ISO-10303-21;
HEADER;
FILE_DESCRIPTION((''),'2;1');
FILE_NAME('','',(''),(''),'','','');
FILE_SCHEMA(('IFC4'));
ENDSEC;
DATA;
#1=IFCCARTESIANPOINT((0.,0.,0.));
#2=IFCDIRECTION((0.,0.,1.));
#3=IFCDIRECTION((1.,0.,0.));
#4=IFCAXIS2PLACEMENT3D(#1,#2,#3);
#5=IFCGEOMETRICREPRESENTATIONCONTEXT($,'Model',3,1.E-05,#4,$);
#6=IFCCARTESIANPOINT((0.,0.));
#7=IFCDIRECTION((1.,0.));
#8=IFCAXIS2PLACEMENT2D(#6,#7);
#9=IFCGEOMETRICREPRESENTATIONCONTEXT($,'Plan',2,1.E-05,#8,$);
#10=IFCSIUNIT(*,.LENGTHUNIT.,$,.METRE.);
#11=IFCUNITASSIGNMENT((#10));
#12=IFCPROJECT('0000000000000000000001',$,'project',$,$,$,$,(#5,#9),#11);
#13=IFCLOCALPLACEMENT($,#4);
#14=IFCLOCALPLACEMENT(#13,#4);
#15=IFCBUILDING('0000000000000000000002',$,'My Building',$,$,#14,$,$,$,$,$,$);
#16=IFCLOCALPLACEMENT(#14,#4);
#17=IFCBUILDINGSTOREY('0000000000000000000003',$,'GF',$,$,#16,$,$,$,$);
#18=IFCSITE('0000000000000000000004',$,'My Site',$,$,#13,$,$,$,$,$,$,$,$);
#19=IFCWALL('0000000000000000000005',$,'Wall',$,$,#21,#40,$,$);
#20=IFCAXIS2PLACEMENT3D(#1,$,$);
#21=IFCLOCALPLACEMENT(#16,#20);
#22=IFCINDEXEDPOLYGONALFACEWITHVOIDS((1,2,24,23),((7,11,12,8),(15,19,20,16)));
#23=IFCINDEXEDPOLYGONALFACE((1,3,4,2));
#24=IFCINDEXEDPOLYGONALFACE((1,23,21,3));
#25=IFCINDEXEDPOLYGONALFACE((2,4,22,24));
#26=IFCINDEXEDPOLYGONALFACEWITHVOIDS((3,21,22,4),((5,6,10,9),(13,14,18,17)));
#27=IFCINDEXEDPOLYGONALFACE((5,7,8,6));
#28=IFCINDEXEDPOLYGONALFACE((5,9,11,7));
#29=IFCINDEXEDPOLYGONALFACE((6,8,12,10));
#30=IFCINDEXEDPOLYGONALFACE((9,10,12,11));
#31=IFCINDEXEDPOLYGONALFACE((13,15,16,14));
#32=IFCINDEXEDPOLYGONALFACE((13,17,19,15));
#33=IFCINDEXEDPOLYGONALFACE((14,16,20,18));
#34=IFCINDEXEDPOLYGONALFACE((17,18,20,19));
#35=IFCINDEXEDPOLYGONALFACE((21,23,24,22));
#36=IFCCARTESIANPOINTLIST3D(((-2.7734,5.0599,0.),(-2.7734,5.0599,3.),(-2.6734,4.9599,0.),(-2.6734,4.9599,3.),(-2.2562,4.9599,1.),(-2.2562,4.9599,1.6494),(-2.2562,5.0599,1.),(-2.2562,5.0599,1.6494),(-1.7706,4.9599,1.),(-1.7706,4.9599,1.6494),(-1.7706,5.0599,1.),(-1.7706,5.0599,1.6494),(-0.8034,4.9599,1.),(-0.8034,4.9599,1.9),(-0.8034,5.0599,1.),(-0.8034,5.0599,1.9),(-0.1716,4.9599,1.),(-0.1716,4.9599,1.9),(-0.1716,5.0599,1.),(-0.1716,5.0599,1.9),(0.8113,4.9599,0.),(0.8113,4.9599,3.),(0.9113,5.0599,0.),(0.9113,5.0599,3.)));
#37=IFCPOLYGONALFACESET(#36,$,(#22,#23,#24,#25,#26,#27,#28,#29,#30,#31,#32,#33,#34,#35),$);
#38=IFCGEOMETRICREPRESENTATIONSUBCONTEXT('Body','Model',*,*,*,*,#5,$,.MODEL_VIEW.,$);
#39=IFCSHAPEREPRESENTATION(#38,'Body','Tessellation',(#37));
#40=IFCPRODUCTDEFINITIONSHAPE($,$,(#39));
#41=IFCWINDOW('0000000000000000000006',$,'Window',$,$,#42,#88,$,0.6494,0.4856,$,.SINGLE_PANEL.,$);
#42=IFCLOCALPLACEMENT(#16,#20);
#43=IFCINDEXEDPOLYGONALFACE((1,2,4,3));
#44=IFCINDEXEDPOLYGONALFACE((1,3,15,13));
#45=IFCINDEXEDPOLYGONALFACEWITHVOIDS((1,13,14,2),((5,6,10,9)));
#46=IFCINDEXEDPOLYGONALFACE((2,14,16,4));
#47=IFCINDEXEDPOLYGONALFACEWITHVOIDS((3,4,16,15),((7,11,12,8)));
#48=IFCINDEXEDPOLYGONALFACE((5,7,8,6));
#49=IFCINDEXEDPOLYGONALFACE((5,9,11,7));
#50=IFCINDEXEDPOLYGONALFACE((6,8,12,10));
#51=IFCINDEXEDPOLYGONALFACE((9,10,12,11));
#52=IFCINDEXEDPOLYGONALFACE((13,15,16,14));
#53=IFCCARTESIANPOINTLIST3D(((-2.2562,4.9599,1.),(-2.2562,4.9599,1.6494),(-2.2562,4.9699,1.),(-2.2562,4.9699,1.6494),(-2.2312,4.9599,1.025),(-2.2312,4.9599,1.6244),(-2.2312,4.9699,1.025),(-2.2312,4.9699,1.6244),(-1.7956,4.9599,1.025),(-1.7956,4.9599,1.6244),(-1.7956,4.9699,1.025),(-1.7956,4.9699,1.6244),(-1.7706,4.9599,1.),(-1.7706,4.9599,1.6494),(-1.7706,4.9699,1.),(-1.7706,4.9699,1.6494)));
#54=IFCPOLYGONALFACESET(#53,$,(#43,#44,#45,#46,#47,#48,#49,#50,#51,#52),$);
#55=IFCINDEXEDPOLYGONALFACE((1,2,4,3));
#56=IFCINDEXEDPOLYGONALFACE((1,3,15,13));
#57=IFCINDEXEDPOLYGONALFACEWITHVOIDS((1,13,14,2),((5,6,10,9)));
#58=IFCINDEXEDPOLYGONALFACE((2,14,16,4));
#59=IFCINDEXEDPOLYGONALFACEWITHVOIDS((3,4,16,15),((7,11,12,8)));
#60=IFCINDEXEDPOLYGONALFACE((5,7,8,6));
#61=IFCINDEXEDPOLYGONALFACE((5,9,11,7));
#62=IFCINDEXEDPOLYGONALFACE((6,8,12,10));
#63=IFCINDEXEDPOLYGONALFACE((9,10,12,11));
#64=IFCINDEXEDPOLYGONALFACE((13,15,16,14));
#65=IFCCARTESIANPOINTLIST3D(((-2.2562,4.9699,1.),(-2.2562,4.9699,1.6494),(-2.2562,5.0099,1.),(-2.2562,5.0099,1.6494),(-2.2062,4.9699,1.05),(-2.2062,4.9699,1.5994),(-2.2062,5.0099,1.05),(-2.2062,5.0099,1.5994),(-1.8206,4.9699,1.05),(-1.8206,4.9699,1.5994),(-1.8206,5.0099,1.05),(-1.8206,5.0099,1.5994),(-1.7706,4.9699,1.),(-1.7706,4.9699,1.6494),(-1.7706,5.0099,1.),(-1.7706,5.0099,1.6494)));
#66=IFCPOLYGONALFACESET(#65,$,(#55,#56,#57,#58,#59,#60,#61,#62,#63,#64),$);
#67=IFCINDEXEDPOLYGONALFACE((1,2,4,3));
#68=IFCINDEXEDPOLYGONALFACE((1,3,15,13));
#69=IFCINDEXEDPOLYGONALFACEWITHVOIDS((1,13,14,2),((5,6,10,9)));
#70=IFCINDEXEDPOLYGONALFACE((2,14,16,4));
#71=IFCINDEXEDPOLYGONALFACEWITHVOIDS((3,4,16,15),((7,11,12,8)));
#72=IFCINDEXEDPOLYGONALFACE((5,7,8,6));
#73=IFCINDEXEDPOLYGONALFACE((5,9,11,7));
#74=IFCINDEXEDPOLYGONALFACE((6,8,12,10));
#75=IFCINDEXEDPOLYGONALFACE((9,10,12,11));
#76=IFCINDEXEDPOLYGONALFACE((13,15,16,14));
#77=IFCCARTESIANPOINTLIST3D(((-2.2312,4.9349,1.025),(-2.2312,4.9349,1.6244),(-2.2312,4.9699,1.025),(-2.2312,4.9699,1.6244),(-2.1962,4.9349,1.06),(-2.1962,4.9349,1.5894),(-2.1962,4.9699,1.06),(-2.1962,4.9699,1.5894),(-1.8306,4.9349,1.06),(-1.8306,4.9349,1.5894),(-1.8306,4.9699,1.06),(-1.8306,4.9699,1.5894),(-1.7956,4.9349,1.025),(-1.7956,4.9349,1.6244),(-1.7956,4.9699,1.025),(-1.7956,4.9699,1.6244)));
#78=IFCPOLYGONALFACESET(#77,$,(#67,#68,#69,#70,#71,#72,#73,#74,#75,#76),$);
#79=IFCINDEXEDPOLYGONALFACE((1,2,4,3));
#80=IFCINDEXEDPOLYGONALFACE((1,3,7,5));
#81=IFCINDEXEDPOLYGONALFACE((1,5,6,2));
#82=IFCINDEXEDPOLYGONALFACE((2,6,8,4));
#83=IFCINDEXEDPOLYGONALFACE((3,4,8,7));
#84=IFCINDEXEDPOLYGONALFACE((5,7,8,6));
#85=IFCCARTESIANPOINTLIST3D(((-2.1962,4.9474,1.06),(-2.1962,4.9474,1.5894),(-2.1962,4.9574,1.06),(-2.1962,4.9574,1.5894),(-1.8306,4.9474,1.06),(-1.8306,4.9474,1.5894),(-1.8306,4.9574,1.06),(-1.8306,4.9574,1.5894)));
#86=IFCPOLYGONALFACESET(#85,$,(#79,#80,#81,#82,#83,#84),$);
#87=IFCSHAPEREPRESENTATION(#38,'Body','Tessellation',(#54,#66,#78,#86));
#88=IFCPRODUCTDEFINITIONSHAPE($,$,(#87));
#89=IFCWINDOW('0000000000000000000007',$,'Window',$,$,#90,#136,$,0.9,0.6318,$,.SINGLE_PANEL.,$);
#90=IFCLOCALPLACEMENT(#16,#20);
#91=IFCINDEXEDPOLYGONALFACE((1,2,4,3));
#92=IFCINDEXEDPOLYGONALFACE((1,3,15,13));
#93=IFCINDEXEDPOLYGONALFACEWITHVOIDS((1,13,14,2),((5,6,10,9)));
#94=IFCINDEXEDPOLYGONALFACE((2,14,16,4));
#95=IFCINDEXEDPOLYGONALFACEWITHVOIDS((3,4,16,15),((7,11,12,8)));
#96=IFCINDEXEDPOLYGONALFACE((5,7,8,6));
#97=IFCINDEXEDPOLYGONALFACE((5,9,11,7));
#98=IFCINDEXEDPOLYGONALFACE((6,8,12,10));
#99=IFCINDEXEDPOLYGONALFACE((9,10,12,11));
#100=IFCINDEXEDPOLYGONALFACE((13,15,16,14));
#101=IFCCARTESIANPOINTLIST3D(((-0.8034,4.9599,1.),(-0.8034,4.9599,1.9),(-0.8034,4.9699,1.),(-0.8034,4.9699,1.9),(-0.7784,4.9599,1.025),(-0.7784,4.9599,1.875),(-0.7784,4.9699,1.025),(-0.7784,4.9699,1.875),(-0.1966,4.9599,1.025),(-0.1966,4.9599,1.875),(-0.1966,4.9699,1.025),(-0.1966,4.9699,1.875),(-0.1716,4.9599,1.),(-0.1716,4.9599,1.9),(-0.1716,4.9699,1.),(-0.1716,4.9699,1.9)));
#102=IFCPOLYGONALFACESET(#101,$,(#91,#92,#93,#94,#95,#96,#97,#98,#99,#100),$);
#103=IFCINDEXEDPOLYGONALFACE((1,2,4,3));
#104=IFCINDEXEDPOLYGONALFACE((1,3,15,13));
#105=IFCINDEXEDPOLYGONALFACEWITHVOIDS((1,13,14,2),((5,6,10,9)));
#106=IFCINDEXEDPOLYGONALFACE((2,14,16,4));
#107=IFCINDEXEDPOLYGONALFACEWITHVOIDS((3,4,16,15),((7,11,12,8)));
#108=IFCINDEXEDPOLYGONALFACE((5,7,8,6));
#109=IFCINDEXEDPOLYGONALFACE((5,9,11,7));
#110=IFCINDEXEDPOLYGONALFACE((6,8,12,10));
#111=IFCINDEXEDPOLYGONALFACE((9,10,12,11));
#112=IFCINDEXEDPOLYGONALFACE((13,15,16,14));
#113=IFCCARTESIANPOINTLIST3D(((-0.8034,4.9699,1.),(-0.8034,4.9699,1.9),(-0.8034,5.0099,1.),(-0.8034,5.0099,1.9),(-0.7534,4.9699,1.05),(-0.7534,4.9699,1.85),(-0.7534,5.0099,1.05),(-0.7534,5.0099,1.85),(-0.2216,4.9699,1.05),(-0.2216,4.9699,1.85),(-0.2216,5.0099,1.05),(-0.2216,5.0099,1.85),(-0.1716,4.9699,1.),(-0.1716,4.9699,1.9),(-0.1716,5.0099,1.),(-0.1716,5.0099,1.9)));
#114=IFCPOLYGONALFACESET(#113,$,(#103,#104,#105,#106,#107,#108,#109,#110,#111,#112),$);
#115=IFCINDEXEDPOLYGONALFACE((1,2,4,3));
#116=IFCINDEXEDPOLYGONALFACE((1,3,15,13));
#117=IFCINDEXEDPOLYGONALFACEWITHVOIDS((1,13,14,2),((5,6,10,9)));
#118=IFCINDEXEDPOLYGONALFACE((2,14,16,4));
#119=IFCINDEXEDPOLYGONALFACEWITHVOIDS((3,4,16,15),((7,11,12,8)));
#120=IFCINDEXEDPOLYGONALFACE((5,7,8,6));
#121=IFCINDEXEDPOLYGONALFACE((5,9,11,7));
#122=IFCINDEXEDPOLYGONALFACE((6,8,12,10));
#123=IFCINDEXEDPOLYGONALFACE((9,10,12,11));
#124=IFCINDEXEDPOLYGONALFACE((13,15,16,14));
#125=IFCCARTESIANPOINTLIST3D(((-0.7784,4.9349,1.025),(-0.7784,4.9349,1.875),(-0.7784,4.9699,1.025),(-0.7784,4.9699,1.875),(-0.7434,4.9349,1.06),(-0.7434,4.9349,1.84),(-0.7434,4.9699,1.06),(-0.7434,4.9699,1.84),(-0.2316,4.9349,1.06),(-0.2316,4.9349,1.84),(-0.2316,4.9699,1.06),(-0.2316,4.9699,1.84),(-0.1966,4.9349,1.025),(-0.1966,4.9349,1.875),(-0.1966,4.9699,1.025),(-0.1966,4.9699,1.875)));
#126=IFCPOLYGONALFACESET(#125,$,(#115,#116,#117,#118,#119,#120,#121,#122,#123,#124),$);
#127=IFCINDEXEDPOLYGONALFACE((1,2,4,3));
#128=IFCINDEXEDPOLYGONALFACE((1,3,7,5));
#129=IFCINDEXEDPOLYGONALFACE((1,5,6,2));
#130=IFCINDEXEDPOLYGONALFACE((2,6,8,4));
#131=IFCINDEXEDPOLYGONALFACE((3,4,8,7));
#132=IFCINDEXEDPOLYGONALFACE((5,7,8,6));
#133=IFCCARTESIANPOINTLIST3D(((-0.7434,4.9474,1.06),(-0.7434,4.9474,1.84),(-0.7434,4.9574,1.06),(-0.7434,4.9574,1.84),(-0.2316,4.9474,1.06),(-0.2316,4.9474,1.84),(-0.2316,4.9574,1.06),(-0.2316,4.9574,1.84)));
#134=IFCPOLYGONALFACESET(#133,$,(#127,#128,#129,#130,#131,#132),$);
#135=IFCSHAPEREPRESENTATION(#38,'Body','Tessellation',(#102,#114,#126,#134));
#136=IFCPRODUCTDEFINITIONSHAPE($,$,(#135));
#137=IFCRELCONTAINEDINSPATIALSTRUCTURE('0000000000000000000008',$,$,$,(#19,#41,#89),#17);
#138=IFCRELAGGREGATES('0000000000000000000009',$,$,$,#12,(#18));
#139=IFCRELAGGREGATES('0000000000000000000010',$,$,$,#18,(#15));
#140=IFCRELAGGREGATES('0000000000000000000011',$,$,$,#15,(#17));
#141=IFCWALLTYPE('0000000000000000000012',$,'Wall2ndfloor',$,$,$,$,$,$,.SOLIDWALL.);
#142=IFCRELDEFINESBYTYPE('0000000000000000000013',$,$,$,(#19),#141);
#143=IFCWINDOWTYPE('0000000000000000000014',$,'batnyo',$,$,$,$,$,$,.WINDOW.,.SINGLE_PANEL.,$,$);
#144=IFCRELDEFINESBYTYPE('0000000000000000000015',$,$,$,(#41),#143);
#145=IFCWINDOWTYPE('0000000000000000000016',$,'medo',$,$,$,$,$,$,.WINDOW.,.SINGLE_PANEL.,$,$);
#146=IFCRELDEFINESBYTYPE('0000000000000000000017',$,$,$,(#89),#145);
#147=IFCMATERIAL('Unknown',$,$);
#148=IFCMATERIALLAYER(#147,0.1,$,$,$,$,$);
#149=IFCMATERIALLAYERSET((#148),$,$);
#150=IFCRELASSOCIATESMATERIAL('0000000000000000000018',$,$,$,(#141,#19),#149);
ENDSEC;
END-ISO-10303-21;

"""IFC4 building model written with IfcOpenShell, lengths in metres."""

from ifc_helpers import new_model, entity, si_unit, frame, origin_with_axes, origin_2d_with_axis, place, context, subcontext, project, spatial, line, indexed_curve, outline, extrude, shape, source, transform, mapped, material, layer, layer_set, layer_usage, type_object, type_shapes, element, fill, save


model = new_model("IFC4")

# Units and contexts
model_context = context("Model", 3, precision=1e-05, world=origin_with_axes())
plan_context = context("Plan", 2, precision=1e-05, world=origin_2d_with_axis())
body_context_1 = subcontext(model_context, "Body", "Model", "MODEL_VIEW")
body_context_2 = subcontext(plan_context, "Body", "Plan", "PLAN_VIEW")
ifc_project = project(units=[si_unit("LENGTHUNIT", "METRE")], contexts=[model_context, plan_context])

# Site, building, storey
site_placement = place(None, origin_with_axes())
site = spatial("IfcSite", under=ifc_project, at=site_placement, Name="My Site")
building_placement = place(site_placement, origin_with_axes())
building = spatial("IfcBuilding", under=site, at=building_placement, Name="My Building")
storey_placement = place(building_placement, origin_with_axes())
storey = spatial("IfcBuildingStorey", under=building, at=storey_placement, Name="GF")

# Shared definitions
ifc_material = material(Name="Unknown")

# Shared definitions
ifc_layer_1 = layer(ifc_material, 0.1)
ifc_layer_set_1 = layer_set([ifc_layer_1])
wall_type = type_object("IfcWallType", Name="Wall2ndfloor", PredefinedType="SOLIDWALL", material=ifc_layer_set_1)

# Wall, openings, windows
ifc_layer_usage_1 = layer_usage(ifc_layer_set_1, "AXIS2", "POSITIVE", 0.0)
wall_1_placement = place(storey_placement, frame((0.9113, 5.0599, 0.0), z_axis=(0.0, 0.0, 1.0), x_axis=(-1.0, 0.0, 0.0)))
wall_1 = element("IfcWall", 1, at=wall_1_placement, inside=storey, type_object=wall_type, material=ifc_layer_usage_1, Name="Wall", context=body_context_1, shape_type="SweptSolid", body=[
    extrude(outline(indexed_curve([(0.0, 0.0), (0.1, 0.1), (3.5847, 0.1), (3.6847, 0.0)], segments=[line(1, 2, 3, 4, 1)])), origin_with_axes(), (0.0, 0.0, 1.0), 3.0),
])
shared_shape_1 = source(origin_with_axes(), body_context_1, "Body", "SweptSolid", [
    extrude(outline(indexed_curve([(0.0, 0.0), (0.4856, 0.0), (0.4856, 0.6494), (0.0, 0.6494)], segments=[line(1, 2, 3, 4, 1)])), frame((0.0, -0.6, 0.0), z_axis=(0.0, -1.0, 0.0), x_axis=(1.0, 0.0, 0.0)), (0.0, 0.0, -1.0), 1.2),
])
opening_1_placement = place(wall_1_placement, frame((2.6819, 0.0, 1.0), z_axis=(0.0, 0.0, 1.0), x_axis=(1.0, 0.0, 0.0)))
opening_1 = element("IfcOpeningElement", 2, at=opening_1_placement, cuts=wall_1, PredefinedType="OPENING", context=body_context_1, shape_type="MappedRepresentation", body=[
    mapped(shared_shape_1, transform((0.0, 0.0, 0.0), x_axis=(1.0, 0.0, 0.0), y_axis=(0.0, 1.0, 0.0), z_axis=(0.0, 0.0, 1.0), scale=1.0)),
])
shared_shape_2 = source(origin_with_axes(), body_context_1, "Body", "SweptSolid", [
    extrude(outline(indexed_curve([(0.0, 0.0), (0.6318, 0.0), (0.6318, 0.9), (0.0, 0.9)], segments=[line(1, 2, 3, 4, 1)])), frame((0.0, -0.6, 0.0), z_axis=(0.0, -1.0, 0.0), x_axis=(1.0, 0.0, 0.0)), (0.0, 0.0, -1.0), 1.2),
])
opening_2_placement = place(wall_1_placement, frame((1.083, 0.0, 1.0), z_axis=(0.0, 0.0, 1.0), x_axis=(1.0, 0.0, 0.0)))
opening_2 = element("IfcOpeningElement", 3, at=opening_2_placement, cuts=wall_1, PredefinedType="OPENING", context=body_context_1, shape_type="MappedRepresentation", body=[
    mapped(shared_shape_2, transform((0.0, 0.0, 0.0), x_axis=(1.0, 0.0, 0.0), y_axis=(0.0, 1.0, 0.0), z_axis=(0.0, 0.0, 1.0), scale=1.0)),
])
window_type_1 = type_object("IfcWindowType", Name="batnyo", PartitioningType="SINGLE_PANEL", PredefinedType="WINDOW")
shared_shape_3 = source(origin_with_axes(), body_context_1, "Body", "SweptSolid", [
    extrude(outline(indexed_curve([(0.0, 0.0), (0.4856, 0.0), (0.4856, 0.6494), (0.0, 0.6494)], segments=[line(1, 2, 3, 4, 1)]), holes=[indexed_curve([(0.025, 0.025), (0.4606, 0.025), (0.4606, 0.6244), (0.025, 0.6244)], segments=[line(1, 2, 3, 4, 1)])]), frame((0.0, 0.09, 0.0), z_axis=(0.0, -1.0, 0.0), x_axis=(1.0, 0.0, 0.0)), (0.0, 0.0, -1.0), 0.01),
    extrude(outline(indexed_curve([(0.0, 0.0), (0.4856, 0.0), (0.4856, 0.6494), (0.0, 0.6494)], segments=[line(1, 2, 3, 4, 1)]), holes=[indexed_curve([(0.05, 0.05), (0.4356, 0.05), (0.4356, 0.5994), (0.05, 0.5994)], segments=[line(1, 2, 3, 4, 1)])]), frame((0.0, 0.05, 0.0), z_axis=(0.0, -1.0, 0.0), x_axis=(1.0, 0.0, 0.0)), (0.0, 0.0, -1.0), 0.04),
    extrude(outline(indexed_curve([(0.0, 0.0), (0.4356, 0.0), (0.4356, 0.5994), (0.0, 0.5994)], segments=[line(1, 2, 3, 4, 1)]), holes=[indexed_curve([(0.035, 0.035), (0.4006, 0.035), (0.4006, 0.5644), (0.035, 0.5644)], segments=[line(1, 2, 3, 4, 1)])]), frame((0.025, 0.09, 0.025), z_axis=(0.0, -1.0, 0.0), x_axis=(1.0, 0.0, 0.0)), (0.0, 0.0, -1.0), 0.035),
    extrude(outline(indexed_curve([(0.035, 0.035), (0.4006, 0.035), (0.4006, 0.5644), (0.035, 0.5644)], segments=[line(1, 2, 3, 4, 1)])), frame((0.025, 0.1025, 0.025), z_axis=(0.0, -1.0, 0.0), x_axis=(1.0, 0.0, 0.0)), (0.0, 0.0, -1.0), 0.01),
])
shared_shape_4 = source(origin_with_axes(), body_context_2, "Body", "Curve2D", [
    entity("IfcIndexedPolyCurve", entity("IfcCartesianPointList2D", [[0.05, 0.05], [0.4356, 0.05]])),
    entity("IfcIndexedPolyCurve", entity("IfcCartesianPointList2D", [[0.0, 0.1], [0.025, 0.1], [0.025, 0.09], [0.05, 0.09], [0.05, 0.05], [0.0, 0.05]]), [entity("IfcLineIndex", [1, 2, 3, 4, 5, 6, 1])]),
    entity("IfcIndexedPolyCurve", entity("IfcCartesianPointList2D", [[0.4856, 0.1], [0.4606, 0.1], [0.4606, 0.09], [0.4356, 0.09], [0.4356, 0.05], [0.4856, 0.05]]), [entity("IfcLineIndex", [1, 2, 3, 4, 5, 6, 1])]),
    entity("IfcIndexedPolyCurve", entity("IfcCartesianPointList2D", [[0.025, 0.09], [0.06, 0.09], [0.06, 0.125], [0.025, 0.125]]), [entity("IfcLineIndex", [1, 2, 3, 4, 1])]),
    entity("IfcIndexedPolyCurve", entity("IfcCartesianPointList2D", [[0.4606, 0.09], [0.4256, 0.09], [0.4256, 0.125], [0.4606, 0.125]]), [entity("IfcLineIndex", [1, 2, 3, 4, 1])]),
    entity("IfcIndexedPolyCurve", entity("IfcCartesianPointList2D", [[0.06, 0.09], [0.4256, 0.09]])),
    entity("IfcIndexedPolyCurve", entity("IfcCartesianPointList2D", [[0.06, 0.125], [0.4256, 0.125]])),
    entity("IfcIndexedPolyCurve", entity("IfcCartesianPointList2D", [[0.06, 0.1075], [0.4256, 0.1075]])),
])
type_shapes(window_type_1, [shared_shape_3, shared_shape_4])
window_1_placement = place(opening_1_placement, frame((0.0, 0.0, 0.0), z_axis=(0.0, 0.0, 1.0), x_axis=(1.0, 0.0, 0.0)))
window_1 = element("IfcWindow", 4, at=window_1_placement, inside=storey, type_object=window_type_1, Name="Window", OverallHeight=0.6494, OverallWidth=0.4856, PartitioningType="SINGLE_PANEL", shapes=[
    shape(body_context_1, "Body", "MappedRepresentation", [mapped(shared_shape_3, transform((0.0, 0.0, 0.0), x_axis=(1.0, 0.0, 0.0), y_axis=(0.0, 1.0, 0.0), z_axis=(0.0, 0.0, 1.0), scale=1.0))]),
    shape(body_context_2, "Body", "MappedRepresentation", [mapped(shared_shape_4, transform((0.0, 0.0, 0.0), x_axis=(1.0, 0.0, 0.0), y_axis=(0.0, 1.0, 0.0), z_axis=(0.0, 0.0, 1.0), scale=1.0))]),
])
fill(opening_1, window_1)
window_type_2 = type_object("IfcWindowType", Name="medo", PartitioningType="SINGLE_PANEL", PredefinedType="WINDOW")
shared_shape_5 = source(origin_with_axes(), body_context_1, "Body", "SweptSolid", [
    extrude(outline(indexed_curve([(0.0, 0.0), (0.6318, 0.0), (0.6318, 0.9), (0.0, 0.9)], segments=[line(1, 2, 3, 4, 1)]), holes=[indexed_curve([(0.025, 0.025), (0.6068, 0.025), (0.6068, 0.875), (0.025, 0.875)], segments=[line(1, 2, 3, 4, 1)])]), frame((0.0, 0.09, 0.0), z_axis=(0.0, -1.0, 0.0), x_axis=(1.0, 0.0, 0.0)), (0.0, 0.0, -1.0), 0.01),
    extrude(outline(indexed_curve([(0.0, 0.0), (0.6318, 0.0), (0.6318, 0.9), (0.0, 0.9)], segments=[line(1, 2, 3, 4, 1)]), holes=[indexed_curve([(0.05, 0.05), (0.5818, 0.05), (0.5818, 0.85), (0.05, 0.85)], segments=[line(1, 2, 3, 4, 1)])]), frame((0.0, 0.05, 0.0), z_axis=(0.0, -1.0, 0.0), x_axis=(1.0, 0.0, 0.0)), (0.0, 0.0, -1.0), 0.04),
    extrude(outline(indexed_curve([(0.0, 0.0), (0.5818, 0.0), (0.5818, 0.85), (0.0, 0.85)], segments=[line(1, 2, 3, 4, 1)]), holes=[indexed_curve([(0.035, 0.035), (0.5468, 0.035), (0.5468, 0.815), (0.035, 0.815)], segments=[line(1, 2, 3, 4, 1)])]), frame((0.025, 0.09, 0.025), z_axis=(0.0, -1.0, 0.0), x_axis=(1.0, 0.0, 0.0)), (0.0, 0.0, -1.0), 0.035),
    extrude(outline(indexed_curve([(0.035, 0.035), (0.5468, 0.035), (0.5468, 0.815), (0.035, 0.815)], segments=[line(1, 2, 3, 4, 1)])), frame((0.025, 0.1025, 0.025), z_axis=(0.0, -1.0, 0.0), x_axis=(1.0, 0.0, 0.0)), (0.0, 0.0, -1.0), 0.01),
])
shared_shape_6 = source(origin_with_axes(), body_context_2, "Body", "Curve2D", [
    entity("IfcIndexedPolyCurve", entity("IfcCartesianPointList2D", [[0.05, 0.05], [0.5818, 0.05]])),
    entity("IfcIndexedPolyCurve", entity("IfcCartesianPointList2D", [[0.0, 0.1], [0.025, 0.1], [0.025, 0.09], [0.05, 0.09], [0.05, 0.05], [0.0, 0.05]]), [entity("IfcLineIndex", [1, 2, 3, 4, 5, 6, 1])]),
    entity("IfcIndexedPolyCurve", entity("IfcCartesianPointList2D", [[0.6318, 0.1], [0.6068, 0.1], [0.6068, 0.09], [0.5818, 0.09], [0.5818, 0.05], [0.6318, 0.05]]), [entity("IfcLineIndex", [1, 2, 3, 4, 5, 6, 1])]),
    entity("IfcIndexedPolyCurve", entity("IfcCartesianPointList2D", [[0.025, 0.09], [0.06, 0.09], [0.06, 0.125], [0.025, 0.125]]), [entity("IfcLineIndex", [1, 2, 3, 4, 1])]),
    entity("IfcIndexedPolyCurve", entity("IfcCartesianPointList2D", [[0.6068, 0.09], [0.5718, 0.09], [0.5718, 0.125], [0.6068, 0.125]]), [entity("IfcLineIndex", [1, 2, 3, 4, 1])]),
    entity("IfcIndexedPolyCurve", entity("IfcCartesianPointList2D", [[0.06, 0.09], [0.5718, 0.09]])),
    entity("IfcIndexedPolyCurve", entity("IfcCartesianPointList2D", [[0.06, 0.125], [0.5718, 0.125]])),
    entity("IfcIndexedPolyCurve", entity("IfcCartesianPointList2D", [[0.06, 0.1075], [0.5718, 0.1075]])),
])
type_shapes(window_type_2, [shared_shape_5, shared_shape_6])
window_2_placement = place(opening_2_placement, frame((0.0, 0.0, 0.0), z_axis=(0.0, 0.0, 1.0), x_axis=(1.0, 0.0, 0.0)))
window_2 = element("IfcWindow", 5, at=window_2_placement, inside=storey, type_object=window_type_2, Name="Window", OverallHeight=0.9, OverallWidth=0.6318, PartitioningType="SINGLE_PANEL", shapes=[
    shape(body_context_1, "Body", "MappedRepresentation", [mapped(shared_shape_5, transform((0.0, 0.0, 0.0), x_axis=(1.0, 0.0, 0.0), y_axis=(0.0, 1.0, 0.0), z_axis=(0.0, 0.0, 1.0), scale=1.0))]),
    shape(body_context_2, "Body", "MappedRepresentation", [mapped(shared_shape_6, transform((0.0, 0.0, 0.0), x_axis=(1.0, 0.0, 0.0), y_axis=(0.0, 1.0, 0.0), z_axis=(0.0, 0.0, 1.0), scale=1.0))]),
])
fill(opening_2, window_2)

save(model, "model.ifc")
